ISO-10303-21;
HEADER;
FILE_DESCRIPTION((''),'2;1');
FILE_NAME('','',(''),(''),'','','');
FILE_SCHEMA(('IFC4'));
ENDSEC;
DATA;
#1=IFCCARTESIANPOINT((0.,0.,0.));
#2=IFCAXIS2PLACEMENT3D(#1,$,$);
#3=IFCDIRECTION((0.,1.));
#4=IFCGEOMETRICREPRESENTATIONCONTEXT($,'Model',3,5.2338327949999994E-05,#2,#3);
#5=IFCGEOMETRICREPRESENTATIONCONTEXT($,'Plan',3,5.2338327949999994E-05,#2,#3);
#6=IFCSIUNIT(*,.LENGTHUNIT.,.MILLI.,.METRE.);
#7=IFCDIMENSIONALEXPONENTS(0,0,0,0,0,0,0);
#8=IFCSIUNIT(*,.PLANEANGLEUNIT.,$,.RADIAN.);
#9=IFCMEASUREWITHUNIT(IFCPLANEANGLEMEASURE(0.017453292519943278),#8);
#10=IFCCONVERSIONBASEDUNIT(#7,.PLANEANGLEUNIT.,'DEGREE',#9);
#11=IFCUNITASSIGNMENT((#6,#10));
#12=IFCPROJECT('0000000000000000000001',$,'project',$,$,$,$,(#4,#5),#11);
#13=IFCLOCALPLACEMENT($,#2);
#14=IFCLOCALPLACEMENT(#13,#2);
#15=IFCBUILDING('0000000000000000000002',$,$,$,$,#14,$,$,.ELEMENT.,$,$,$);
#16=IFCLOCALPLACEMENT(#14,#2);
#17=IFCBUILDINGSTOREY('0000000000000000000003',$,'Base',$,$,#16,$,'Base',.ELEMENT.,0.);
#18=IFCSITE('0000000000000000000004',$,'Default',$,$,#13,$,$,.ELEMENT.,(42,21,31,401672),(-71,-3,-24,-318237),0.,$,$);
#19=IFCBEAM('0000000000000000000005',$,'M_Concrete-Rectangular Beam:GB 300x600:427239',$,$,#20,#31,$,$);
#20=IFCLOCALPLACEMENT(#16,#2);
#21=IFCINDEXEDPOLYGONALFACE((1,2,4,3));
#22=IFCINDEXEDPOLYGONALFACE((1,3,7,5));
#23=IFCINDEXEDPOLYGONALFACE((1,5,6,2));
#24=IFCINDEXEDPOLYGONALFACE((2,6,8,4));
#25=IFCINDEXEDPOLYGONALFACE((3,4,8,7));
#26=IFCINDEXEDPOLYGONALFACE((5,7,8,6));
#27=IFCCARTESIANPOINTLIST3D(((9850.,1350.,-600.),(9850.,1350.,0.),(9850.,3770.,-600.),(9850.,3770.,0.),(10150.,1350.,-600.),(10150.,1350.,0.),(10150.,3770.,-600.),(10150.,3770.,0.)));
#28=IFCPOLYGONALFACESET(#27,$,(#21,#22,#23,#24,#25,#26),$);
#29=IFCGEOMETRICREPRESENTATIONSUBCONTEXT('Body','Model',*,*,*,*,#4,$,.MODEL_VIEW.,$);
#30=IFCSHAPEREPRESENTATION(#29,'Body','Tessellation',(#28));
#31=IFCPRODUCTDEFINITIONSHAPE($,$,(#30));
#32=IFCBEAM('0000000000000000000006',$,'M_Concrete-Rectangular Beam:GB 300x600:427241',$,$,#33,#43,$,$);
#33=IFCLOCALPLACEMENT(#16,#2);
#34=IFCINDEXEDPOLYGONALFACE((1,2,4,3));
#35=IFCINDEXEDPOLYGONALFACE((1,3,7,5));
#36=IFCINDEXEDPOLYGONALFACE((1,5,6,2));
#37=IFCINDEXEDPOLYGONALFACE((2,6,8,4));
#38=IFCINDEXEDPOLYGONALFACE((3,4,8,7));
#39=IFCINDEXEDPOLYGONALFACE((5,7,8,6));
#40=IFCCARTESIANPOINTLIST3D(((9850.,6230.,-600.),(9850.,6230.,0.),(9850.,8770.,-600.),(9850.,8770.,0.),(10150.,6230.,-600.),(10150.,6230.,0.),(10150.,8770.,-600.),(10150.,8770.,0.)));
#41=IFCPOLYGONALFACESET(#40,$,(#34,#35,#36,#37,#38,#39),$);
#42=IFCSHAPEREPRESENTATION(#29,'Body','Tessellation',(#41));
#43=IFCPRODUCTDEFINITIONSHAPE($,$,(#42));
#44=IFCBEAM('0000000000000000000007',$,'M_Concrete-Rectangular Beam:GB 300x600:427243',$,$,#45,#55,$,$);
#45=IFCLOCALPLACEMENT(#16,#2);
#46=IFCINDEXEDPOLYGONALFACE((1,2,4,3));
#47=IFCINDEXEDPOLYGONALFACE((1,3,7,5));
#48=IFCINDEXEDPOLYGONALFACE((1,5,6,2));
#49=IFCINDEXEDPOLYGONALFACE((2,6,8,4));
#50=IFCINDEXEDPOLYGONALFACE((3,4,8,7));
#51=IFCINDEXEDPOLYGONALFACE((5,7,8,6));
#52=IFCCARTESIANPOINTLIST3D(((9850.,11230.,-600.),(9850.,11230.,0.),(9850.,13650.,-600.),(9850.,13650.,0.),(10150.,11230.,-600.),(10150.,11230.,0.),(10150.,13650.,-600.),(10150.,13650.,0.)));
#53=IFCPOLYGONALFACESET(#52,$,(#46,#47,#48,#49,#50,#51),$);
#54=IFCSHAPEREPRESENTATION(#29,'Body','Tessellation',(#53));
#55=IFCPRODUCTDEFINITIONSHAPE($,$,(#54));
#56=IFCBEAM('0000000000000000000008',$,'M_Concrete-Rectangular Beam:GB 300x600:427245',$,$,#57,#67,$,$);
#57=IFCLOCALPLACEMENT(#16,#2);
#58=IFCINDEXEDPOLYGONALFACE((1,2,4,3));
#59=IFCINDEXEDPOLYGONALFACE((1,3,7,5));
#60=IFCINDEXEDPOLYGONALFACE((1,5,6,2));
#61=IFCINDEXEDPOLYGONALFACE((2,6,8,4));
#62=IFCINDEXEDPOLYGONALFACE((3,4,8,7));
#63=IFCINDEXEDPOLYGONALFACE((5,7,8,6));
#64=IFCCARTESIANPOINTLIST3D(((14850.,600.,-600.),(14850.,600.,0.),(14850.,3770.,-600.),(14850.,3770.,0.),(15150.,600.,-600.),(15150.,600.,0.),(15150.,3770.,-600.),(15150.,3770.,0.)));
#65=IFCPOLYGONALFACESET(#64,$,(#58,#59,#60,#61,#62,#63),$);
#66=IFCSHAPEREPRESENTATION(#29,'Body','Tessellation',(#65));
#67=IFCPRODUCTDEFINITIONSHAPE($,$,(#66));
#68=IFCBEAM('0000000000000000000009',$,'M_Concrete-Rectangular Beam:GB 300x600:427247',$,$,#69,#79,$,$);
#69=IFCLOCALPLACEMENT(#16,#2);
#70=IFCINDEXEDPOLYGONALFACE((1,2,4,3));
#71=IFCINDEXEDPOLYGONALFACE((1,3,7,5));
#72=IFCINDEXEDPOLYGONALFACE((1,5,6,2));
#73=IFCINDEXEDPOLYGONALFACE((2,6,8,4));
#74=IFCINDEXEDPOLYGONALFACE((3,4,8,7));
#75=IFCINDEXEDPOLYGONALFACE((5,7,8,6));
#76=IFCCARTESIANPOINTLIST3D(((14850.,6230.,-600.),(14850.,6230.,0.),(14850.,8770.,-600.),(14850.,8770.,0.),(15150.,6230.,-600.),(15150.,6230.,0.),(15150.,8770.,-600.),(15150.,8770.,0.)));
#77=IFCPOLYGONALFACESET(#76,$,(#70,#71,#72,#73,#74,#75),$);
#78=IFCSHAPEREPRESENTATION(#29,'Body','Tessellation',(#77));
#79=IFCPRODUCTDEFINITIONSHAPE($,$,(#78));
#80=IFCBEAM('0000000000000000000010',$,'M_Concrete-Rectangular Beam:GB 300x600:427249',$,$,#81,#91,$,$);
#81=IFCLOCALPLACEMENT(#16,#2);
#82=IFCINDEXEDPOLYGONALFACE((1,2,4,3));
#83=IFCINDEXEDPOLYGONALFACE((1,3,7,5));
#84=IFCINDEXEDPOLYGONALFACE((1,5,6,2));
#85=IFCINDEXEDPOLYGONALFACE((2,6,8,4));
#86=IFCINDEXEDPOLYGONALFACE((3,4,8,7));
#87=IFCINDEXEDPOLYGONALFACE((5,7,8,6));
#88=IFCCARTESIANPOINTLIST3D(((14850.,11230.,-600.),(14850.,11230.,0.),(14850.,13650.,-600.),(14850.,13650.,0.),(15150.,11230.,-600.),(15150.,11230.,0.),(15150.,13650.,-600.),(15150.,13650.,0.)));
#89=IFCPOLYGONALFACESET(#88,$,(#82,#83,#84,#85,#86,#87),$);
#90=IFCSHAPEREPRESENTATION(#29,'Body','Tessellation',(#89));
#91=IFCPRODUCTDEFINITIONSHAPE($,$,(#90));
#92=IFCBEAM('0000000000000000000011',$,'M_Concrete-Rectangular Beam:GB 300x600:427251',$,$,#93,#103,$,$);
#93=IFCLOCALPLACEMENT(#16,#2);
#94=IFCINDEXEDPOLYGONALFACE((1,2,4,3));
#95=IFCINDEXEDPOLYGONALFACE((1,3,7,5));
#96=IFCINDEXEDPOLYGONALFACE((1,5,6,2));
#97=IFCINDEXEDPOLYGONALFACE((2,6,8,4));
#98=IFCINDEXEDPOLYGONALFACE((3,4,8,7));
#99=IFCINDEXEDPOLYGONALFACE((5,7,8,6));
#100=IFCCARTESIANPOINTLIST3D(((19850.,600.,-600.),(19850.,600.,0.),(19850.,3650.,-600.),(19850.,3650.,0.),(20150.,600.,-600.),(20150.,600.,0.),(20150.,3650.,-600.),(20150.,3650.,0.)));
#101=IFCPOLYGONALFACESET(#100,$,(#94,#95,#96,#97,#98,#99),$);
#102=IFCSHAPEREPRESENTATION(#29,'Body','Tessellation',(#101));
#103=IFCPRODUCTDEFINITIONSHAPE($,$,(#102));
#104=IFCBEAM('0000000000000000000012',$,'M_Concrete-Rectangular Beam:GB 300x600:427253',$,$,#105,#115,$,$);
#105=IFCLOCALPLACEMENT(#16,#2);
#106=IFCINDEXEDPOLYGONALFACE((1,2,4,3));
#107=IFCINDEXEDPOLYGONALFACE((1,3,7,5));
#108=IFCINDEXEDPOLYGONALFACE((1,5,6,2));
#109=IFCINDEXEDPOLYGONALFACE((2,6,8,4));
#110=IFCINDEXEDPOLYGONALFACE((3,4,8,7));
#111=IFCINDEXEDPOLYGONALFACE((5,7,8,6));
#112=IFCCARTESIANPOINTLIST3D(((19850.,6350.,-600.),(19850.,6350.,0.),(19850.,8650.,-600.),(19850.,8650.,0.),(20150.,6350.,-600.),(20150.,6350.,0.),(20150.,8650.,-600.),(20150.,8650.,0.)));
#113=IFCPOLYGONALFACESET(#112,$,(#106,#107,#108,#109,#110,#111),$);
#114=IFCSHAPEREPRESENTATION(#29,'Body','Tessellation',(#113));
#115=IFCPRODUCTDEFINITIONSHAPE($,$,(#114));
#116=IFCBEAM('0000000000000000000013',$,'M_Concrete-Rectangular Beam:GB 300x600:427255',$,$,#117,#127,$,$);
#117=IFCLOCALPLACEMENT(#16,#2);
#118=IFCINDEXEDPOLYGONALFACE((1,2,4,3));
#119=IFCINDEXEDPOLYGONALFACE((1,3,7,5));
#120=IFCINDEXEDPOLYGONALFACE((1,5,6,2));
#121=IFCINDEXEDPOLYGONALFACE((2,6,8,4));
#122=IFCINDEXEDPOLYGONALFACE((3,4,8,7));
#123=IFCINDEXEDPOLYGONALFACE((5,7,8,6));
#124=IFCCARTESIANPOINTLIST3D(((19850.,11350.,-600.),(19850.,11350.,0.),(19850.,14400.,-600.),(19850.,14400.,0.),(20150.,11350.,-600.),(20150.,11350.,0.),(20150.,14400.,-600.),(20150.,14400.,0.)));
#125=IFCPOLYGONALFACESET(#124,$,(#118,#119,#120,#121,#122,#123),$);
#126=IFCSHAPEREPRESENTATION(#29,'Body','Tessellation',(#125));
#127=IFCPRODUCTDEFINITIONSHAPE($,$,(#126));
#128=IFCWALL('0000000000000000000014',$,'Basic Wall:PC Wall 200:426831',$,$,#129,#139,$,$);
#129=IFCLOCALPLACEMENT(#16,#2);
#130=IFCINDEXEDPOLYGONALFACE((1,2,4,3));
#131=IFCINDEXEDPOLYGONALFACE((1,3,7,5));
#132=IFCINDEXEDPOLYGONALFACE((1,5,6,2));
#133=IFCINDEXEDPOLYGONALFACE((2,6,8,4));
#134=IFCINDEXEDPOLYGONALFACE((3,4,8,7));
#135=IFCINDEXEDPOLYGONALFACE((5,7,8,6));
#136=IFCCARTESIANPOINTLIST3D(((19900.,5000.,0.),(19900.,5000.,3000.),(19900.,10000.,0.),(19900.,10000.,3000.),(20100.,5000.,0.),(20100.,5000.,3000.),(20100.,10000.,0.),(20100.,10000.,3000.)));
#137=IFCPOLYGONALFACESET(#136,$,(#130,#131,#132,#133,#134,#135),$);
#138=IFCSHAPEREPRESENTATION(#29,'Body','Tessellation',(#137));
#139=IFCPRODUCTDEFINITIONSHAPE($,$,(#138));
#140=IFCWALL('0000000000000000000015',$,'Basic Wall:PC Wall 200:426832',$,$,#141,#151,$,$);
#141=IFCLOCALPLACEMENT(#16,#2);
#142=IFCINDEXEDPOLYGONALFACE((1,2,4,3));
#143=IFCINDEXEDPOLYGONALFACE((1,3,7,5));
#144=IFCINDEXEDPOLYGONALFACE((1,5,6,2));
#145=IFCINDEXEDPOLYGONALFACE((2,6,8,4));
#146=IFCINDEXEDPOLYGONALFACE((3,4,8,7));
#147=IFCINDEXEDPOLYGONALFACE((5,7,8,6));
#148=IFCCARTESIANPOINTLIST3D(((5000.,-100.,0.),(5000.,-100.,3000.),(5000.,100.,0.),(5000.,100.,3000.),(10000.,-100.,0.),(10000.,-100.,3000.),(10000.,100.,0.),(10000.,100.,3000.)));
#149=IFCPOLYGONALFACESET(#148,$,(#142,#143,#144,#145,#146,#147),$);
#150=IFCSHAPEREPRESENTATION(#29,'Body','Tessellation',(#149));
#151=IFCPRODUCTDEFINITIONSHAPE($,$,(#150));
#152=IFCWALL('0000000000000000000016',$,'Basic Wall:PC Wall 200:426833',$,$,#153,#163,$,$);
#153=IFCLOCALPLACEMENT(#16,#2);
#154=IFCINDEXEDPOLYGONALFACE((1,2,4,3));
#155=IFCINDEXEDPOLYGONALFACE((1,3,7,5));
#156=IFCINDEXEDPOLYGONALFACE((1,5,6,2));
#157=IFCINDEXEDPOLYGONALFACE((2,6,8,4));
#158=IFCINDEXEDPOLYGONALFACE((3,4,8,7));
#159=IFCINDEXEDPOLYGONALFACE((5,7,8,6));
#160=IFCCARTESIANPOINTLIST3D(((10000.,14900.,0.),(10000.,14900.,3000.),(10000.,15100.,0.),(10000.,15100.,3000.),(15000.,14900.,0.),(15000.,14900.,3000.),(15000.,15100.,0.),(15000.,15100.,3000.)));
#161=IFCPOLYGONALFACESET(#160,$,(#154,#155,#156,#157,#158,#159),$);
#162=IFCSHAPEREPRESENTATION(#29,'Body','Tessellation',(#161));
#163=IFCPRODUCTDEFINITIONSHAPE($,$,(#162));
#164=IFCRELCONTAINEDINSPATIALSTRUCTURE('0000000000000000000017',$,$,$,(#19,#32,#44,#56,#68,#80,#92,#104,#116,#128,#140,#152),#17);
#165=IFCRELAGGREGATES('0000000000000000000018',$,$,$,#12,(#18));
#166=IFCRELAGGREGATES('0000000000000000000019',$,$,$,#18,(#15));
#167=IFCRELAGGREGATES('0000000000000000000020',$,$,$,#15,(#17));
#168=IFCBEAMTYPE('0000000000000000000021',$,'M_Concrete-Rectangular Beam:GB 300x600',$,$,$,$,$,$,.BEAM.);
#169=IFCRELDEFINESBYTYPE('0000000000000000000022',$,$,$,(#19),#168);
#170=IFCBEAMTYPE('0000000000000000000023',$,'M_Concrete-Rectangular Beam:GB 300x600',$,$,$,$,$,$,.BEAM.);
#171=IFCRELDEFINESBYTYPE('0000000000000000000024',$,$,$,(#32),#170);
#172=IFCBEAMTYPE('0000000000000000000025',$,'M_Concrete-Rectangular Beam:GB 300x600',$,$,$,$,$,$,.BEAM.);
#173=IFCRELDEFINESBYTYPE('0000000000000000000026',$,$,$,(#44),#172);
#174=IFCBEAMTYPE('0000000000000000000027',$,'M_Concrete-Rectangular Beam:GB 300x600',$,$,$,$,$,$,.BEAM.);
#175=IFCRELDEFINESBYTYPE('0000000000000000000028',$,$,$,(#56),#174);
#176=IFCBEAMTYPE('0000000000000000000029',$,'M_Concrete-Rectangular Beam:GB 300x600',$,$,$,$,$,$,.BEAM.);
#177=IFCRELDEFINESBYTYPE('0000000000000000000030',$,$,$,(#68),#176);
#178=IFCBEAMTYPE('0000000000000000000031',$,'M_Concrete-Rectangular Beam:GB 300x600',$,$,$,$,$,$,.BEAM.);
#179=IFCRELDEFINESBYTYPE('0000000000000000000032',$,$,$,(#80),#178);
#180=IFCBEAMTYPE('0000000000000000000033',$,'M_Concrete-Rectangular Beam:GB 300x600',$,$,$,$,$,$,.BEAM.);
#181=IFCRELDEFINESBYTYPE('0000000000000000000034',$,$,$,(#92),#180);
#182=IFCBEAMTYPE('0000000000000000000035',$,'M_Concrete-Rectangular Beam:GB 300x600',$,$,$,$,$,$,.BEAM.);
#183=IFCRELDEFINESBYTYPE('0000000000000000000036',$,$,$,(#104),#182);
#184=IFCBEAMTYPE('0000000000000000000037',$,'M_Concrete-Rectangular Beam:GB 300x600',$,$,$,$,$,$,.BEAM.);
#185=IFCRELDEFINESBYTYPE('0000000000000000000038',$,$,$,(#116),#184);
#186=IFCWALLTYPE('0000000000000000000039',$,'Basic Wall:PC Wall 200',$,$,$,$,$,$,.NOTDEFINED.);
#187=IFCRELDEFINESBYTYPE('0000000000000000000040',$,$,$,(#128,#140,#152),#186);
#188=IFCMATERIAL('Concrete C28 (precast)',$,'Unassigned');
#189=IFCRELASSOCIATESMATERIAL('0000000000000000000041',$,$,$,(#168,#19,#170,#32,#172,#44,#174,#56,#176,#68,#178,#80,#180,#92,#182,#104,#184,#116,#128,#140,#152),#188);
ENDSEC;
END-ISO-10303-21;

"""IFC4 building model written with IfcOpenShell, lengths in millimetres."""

from ifc_helpers import new_model, entity, si_unit, converted_unit, direction, frame, origin, place, context, subcontext, project, spatial, indexed_curve, outline, extrude, source, transform, mapped, material, type_object, type_shapes, element, save


model = new_model("IFC4")

# Units and contexts
model_context = context("Model", 3, precision=5.2338327949999994e-05, world=origin(), true_north=direction((0.0, 1.0)))
plan_context = context("Plan", 3, precision=5.2338327949999994e-05, world=origin(), true_north=direction((0.0, 1.0)))
body_context = subcontext(model_context, "Body", "Model", "MODEL_VIEW")
ifc_project = project(units=[si_unit("LENGTHUNIT", "METRE", prefix="MILLI"), converted_unit("PLANEANGLEUNIT", "DEGREE", entity("IfcPlaneAngleMeasure", 0.017453292519943278), si_unit("PLANEANGLEUNIT", "RADIAN"), dimensions=[0, 0, 0, 0, 0, 0, 0])], contexts=[model_context, plan_context])

# Site, building, storey
site_placement = place(None, origin())
site = spatial("IfcSite", under=ifc_project, at=site_placement, Name="Default", CompositionType="ELEMENT", RefLatitude=(42, 21, 31, 401672), RefLongitude=(-71, -3, -24, -318237), RefElevation=0.0)
building_placement = place(site_placement, origin())
building = spatial("IfcBuilding", under=site, at=building_placement, CompositionType="ELEMENT")
storey_placement = place(building_placement, origin())
storey = spatial("IfcBuildingStorey", under=building, at=storey_placement, Name="Base", LongName="Base", CompositionType="ELEMENT", Elevation=0.0)

# Beams
ifc_material = material(Name="Concrete C28 (precast)", Category="Unassigned")
beam_type_1 = type_object("IfcBeamType", Name="M_Concrete-Rectangular Beam:GB 300x600", PredefinedType="BEAM", material=ifc_material)
shared_shape_1 = source(origin(), body_context, "Body", "SweptSolid", [
    extrude(outline(indexed_curve([(-150.0, -300.0), (150.0, -300.0), (150.0, 300.0), (-150.0, 300.0), (-150.0, -300.0)], self_intersect=False)), frame((10000.0, 1350.0, -300.0), z_axis=(0.0, 1.0, 0.0), x_axis=(-1.0, 0.0, 0.0)), (0.0, 0.0, 1.0), 2420.0),
])
type_shapes(beam_type_1, [shared_shape_1])
beam_1_placement = place(storey_placement, origin())
element("IfcBeam", 1, at=beam_1_placement, inside=storey, type_object=beam_type_1, material=ifc_material, Name="M_Concrete-Rectangular Beam:GB 300x600:427239", context=body_context, shape_type="MappedRepresentation", body=[
    mapped(shared_shape_1, transform((0.0, 0.0, 0.0), scale=1.0)),
])
beam_type_2 = type_object("IfcBeamType", Name="M_Concrete-Rectangular Beam:GB 300x600", PredefinedType="BEAM", material=ifc_material)
shared_shape_2 = source(origin(), body_context, "Body", "SweptSolid", [
    extrude(outline(indexed_curve([(-150.0, -300.0), (150.0, -300.0), (150.0, 300.0), (-150.0, 300.0), (-150.0, -300.0)], self_intersect=False)), frame((10000.0, 6230.0, -300.0), z_axis=(0.0, 1.0, 0.0), x_axis=(-1.0, 0.0, 0.0)), (0.0, 0.0, 1.0), 2540.0),
])
type_shapes(beam_type_2, [shared_shape_2])
beam_2_placement = place(storey_placement, origin())
element("IfcBeam", 2, at=beam_2_placement, inside=storey, type_object=beam_type_2, material=ifc_material, Name="M_Concrete-Rectangular Beam:GB 300x600:427241", context=body_context, shape_type="MappedRepresentation", body=[
    mapped(shared_shape_2, transform((0.0, 0.0, 0.0), scale=1.0)),
])
beam_type_3 = type_object("IfcBeamType", Name="M_Concrete-Rectangular Beam:GB 300x600", PredefinedType="BEAM", material=ifc_material)
shared_shape_3 = source(origin(), body_context, "Body", "SweptSolid", [
    extrude(outline(indexed_curve([(-150.0, -300.0), (150.0, -300.0), (150.0, 300.0), (-150.0, 300.0), (-150.0, -300.0)], self_intersect=False)), frame((10000.0, 11230.0, -300.0), z_axis=(0.0, 1.0, 0.0), x_axis=(-1.0, 0.0, 0.0)), (0.0, 0.0, 1.0), 2420.0),
])
type_shapes(beam_type_3, [shared_shape_3])
beam_3_placement = place(storey_placement, origin())
element("IfcBeam", 3, at=beam_3_placement, inside=storey, type_object=beam_type_3, material=ifc_material, Name="M_Concrete-Rectangular Beam:GB 300x600:427243", context=body_context, shape_type="MappedRepresentation", body=[
    mapped(shared_shape_3, transform((0.0, 0.0, 0.0), scale=1.0)),
])
beam_type_4 = type_object("IfcBeamType", Name="M_Concrete-Rectangular Beam:GB 300x600", PredefinedType="BEAM", material=ifc_material)
shared_shape_4 = source(origin(), body_context, "Body", "SweptSolid", [
    extrude(outline(indexed_curve([(-150.0, -300.0), (150.0, -300.0), (150.0, 300.0), (-150.0, 300.0), (-150.0, -300.0)], self_intersect=False)), frame((15000.0, 600.0, -300.0), z_axis=(0.0, 1.0, 0.0), x_axis=(-1.0, 0.0, 0.0)), (0.0, 0.0, 1.0), 3170.0),
])
type_shapes(beam_type_4, [shared_shape_4])
beam_4_placement = place(storey_placement, origin())
element("IfcBeam", 4, at=beam_4_placement, inside=storey, type_object=beam_type_4, material=ifc_material, Name="M_Concrete-Rectangular Beam:GB 300x600:427245", context=body_context, shape_type="MappedRepresentation", body=[
    mapped(shared_shape_4, transform((0.0, 0.0, 0.0), scale=1.0)),
])
beam_type_5 = type_object("IfcBeamType", Name="M_Concrete-Rectangular Beam:GB 300x600", PredefinedType="BEAM", material=ifc_material)
shared_shape_5 = source(origin(), body_context, "Body", "SweptSolid", [
    extrude(outline(indexed_curve([(-150.0, -300.0), (150.0, -300.0), (150.0, 300.0), (-150.0, 300.0), (-150.0, -300.0)], self_intersect=False)), frame((15000.0, 6230.0, -300.0), z_axis=(0.0, 1.0, 0.0), x_axis=(-1.0, 0.0, 0.0)), (0.0, 0.0, 1.0), 2540.0),
])
type_shapes(beam_type_5, [shared_shape_5])
beam_5_placement = place(storey_placement, origin())
element("IfcBeam", 5, at=beam_5_placement, inside=storey, type_object=beam_type_5, material=ifc_material, Name="M_Concrete-Rectangular Beam:GB 300x600:427247", context=body_context, shape_type="MappedRepresentation", body=[
    mapped(shared_shape_5, transform((0.0, 0.0, 0.0), scale=1.0)),
])
beam_type_6 = type_object("IfcBeamType", Name="M_Concrete-Rectangular Beam:GB 300x600", PredefinedType="BEAM", material=ifc_material)
shared_shape_6 = source(origin(), body_context, "Body", "SweptSolid", [
    extrude(outline(indexed_curve([(-150.0, -300.0), (150.0, -300.0), (150.0, 300.0), (-150.0, 300.0), (-150.0, -300.0)], self_intersect=False)), frame((15000.0, 11230.0, -300.0), z_axis=(0.0, 1.0, 0.0), x_axis=(-1.0, 0.0, 0.0)), (0.0, 0.0, 1.0), 2420.0),
])
type_shapes(beam_type_6, [shared_shape_6])
beam_6_placement = place(storey_placement, origin())
element("IfcBeam", 6, at=beam_6_placement, inside=storey, type_object=beam_type_6, material=ifc_material, Name="M_Concrete-Rectangular Beam:GB 300x600:427249", context=body_context, shape_type="MappedRepresentation", body=[
    mapped(shared_shape_6, transform((0.0, 0.0, 0.0), scale=1.0)),
])
beam_type_7 = type_object("IfcBeamType", Name="M_Concrete-Rectangular Beam:GB 300x600", PredefinedType="BEAM", material=ifc_material)
shared_shape_7 = source(origin(), body_context, "Body", "SweptSolid", [
    extrude(outline(indexed_curve([(-150.0, -300.0), (150.0, -300.0), (150.0, 300.0), (-150.0, 300.0), (-150.0, -300.0)], self_intersect=False)), frame((20000.0, 600.0, -300.0), z_axis=(0.0, 1.0, 0.0), x_axis=(-1.0, 0.0, 0.0)), (0.0, 0.0, 1.0), 3050.0),
])
type_shapes(beam_type_7, [shared_shape_7])
beam_7_placement = place(storey_placement, origin())
element("IfcBeam", 7, at=beam_7_placement, inside=storey, type_object=beam_type_7, material=ifc_material, Name="M_Concrete-Rectangular Beam:GB 300x600:427251", context=body_context, shape_type="MappedRepresentation", body=[
    mapped(shared_shape_7, transform((0.0, 0.0, 0.0), scale=1.0)),
])
beam_type_8 = type_object("IfcBeamType", Name="M_Concrete-Rectangular Beam:GB 300x600", PredefinedType="BEAM", material=ifc_material)
shared_shape_8 = source(origin(), body_context, "Body", "SweptSolid", [
    extrude(outline(indexed_curve([(-150.0, -300.0), (150.0, -300.0), (150.0, 300.0), (-150.0, 300.0), (-150.0, -300.0)], self_intersect=False)), frame((20000.0, 6350.0, -300.0), z_axis=(0.0, 1.0, 0.0), x_axis=(-1.0, 0.0, 0.0)), (0.0, 0.0, 1.0), 2300.0),
])
type_shapes(beam_type_8, [shared_shape_8])
beam_8_placement = place(storey_placement, origin())
element("IfcBeam", 8, at=beam_8_placement, inside=storey, type_object=beam_type_8, material=ifc_material, Name="M_Concrete-Rectangular Beam:GB 300x600:427253", context=body_context, shape_type="MappedRepresentation", body=[
    mapped(shared_shape_8, transform((0.0, 0.0, 0.0), scale=1.0)),
])
beam_type_9 = type_object("IfcBeamType", Name="M_Concrete-Rectangular Beam:GB 300x600", PredefinedType="BEAM", material=ifc_material)
shared_shape_9 = source(origin(), body_context, "Body", "SweptSolid", [
    extrude(outline(indexed_curve([(-150.0, -300.0), (150.0, -300.0), (150.0, 300.0), (-150.0, 300.0), (-150.0, -300.0)], self_intersect=False)), frame((20000.0, 11350.0, -300.0), z_axis=(0.0, 1.0, 0.0), x_axis=(-1.0, 0.0, 0.0)), (0.0, 0.0, 1.0), 3050.0),
])
type_shapes(beam_type_9, [shared_shape_9])
beam_9_placement = place(storey_placement, origin())
element("IfcBeam", 9, at=beam_9_placement, inside=storey, type_object=beam_type_9, material=ifc_material, Name="M_Concrete-Rectangular Beam:GB 300x600:427255", context=body_context, shape_type="MappedRepresentation", body=[
    mapped(shared_shape_9, transform((0.0, 0.0, 0.0), scale=1.0)),
])

# Walls
wall_type = type_object("IfcWallType", Name="Basic Wall:PC Wall 200", PredefinedType="NOTDEFINED")
wall_1_placement = place(storey_placement, frame((20000.0, 5000.0, 0.0), z_axis=(0.0, 0.0, 1.0), x_axis=(0.0, 1.0, 0.0)))
element("IfcWall", 10, at=wall_1_placement, inside=storey, type_object=wall_type, material=ifc_material, Name="Basic Wall:PC Wall 200:426831", context=body_context, shape_type="SweptSolid", body=[
    extrude(outline(indexed_curve([(5000.0, 100.0), (0.0, 100.0), (0.0, -100.0), (5000.0, -100.0), (5000.0, 100.0)], self_intersect=False)), origin(), (0.0, 0.0, 1.0), 3000.0),
])
wall_2_placement = place(storey_placement, frame((5000.0, 0.0, 0.0)))
element("IfcWall", 11, at=wall_2_placement, inside=storey, type_object=wall_type, material=ifc_material, Name="Basic Wall:PC Wall 200:426832", context=body_context, shape_type="SweptSolid", body=[
    extrude(outline(indexed_curve([(5000.0, 100.0), (0.0, 100.0), (0.0, -100.0), (5000.0, -100.0), (5000.0, 100.0)], self_intersect=False)), origin(), (0.0, 0.0, 1.0), 3000.0),
])
wall_3_placement = place(storey_placement, frame((10000.0, 15000.0, 0.0)))
element("IfcWall", 12, at=wall_3_placement, inside=storey, type_object=wall_type, material=ifc_material, Name="Basic Wall:PC Wall 200:426833", context=body_context, shape_type="SweptSolid", body=[
    extrude(outline(indexed_curve([(5000.0, 100.0), (0.0, 100.0), (0.0, -100.0), (5000.0, -100.0), (5000.0, 100.0)], self_intersect=False)), origin(), (0.0, 0.0, 1.0), 3000.0),
])

save(model, "model.ifc")
